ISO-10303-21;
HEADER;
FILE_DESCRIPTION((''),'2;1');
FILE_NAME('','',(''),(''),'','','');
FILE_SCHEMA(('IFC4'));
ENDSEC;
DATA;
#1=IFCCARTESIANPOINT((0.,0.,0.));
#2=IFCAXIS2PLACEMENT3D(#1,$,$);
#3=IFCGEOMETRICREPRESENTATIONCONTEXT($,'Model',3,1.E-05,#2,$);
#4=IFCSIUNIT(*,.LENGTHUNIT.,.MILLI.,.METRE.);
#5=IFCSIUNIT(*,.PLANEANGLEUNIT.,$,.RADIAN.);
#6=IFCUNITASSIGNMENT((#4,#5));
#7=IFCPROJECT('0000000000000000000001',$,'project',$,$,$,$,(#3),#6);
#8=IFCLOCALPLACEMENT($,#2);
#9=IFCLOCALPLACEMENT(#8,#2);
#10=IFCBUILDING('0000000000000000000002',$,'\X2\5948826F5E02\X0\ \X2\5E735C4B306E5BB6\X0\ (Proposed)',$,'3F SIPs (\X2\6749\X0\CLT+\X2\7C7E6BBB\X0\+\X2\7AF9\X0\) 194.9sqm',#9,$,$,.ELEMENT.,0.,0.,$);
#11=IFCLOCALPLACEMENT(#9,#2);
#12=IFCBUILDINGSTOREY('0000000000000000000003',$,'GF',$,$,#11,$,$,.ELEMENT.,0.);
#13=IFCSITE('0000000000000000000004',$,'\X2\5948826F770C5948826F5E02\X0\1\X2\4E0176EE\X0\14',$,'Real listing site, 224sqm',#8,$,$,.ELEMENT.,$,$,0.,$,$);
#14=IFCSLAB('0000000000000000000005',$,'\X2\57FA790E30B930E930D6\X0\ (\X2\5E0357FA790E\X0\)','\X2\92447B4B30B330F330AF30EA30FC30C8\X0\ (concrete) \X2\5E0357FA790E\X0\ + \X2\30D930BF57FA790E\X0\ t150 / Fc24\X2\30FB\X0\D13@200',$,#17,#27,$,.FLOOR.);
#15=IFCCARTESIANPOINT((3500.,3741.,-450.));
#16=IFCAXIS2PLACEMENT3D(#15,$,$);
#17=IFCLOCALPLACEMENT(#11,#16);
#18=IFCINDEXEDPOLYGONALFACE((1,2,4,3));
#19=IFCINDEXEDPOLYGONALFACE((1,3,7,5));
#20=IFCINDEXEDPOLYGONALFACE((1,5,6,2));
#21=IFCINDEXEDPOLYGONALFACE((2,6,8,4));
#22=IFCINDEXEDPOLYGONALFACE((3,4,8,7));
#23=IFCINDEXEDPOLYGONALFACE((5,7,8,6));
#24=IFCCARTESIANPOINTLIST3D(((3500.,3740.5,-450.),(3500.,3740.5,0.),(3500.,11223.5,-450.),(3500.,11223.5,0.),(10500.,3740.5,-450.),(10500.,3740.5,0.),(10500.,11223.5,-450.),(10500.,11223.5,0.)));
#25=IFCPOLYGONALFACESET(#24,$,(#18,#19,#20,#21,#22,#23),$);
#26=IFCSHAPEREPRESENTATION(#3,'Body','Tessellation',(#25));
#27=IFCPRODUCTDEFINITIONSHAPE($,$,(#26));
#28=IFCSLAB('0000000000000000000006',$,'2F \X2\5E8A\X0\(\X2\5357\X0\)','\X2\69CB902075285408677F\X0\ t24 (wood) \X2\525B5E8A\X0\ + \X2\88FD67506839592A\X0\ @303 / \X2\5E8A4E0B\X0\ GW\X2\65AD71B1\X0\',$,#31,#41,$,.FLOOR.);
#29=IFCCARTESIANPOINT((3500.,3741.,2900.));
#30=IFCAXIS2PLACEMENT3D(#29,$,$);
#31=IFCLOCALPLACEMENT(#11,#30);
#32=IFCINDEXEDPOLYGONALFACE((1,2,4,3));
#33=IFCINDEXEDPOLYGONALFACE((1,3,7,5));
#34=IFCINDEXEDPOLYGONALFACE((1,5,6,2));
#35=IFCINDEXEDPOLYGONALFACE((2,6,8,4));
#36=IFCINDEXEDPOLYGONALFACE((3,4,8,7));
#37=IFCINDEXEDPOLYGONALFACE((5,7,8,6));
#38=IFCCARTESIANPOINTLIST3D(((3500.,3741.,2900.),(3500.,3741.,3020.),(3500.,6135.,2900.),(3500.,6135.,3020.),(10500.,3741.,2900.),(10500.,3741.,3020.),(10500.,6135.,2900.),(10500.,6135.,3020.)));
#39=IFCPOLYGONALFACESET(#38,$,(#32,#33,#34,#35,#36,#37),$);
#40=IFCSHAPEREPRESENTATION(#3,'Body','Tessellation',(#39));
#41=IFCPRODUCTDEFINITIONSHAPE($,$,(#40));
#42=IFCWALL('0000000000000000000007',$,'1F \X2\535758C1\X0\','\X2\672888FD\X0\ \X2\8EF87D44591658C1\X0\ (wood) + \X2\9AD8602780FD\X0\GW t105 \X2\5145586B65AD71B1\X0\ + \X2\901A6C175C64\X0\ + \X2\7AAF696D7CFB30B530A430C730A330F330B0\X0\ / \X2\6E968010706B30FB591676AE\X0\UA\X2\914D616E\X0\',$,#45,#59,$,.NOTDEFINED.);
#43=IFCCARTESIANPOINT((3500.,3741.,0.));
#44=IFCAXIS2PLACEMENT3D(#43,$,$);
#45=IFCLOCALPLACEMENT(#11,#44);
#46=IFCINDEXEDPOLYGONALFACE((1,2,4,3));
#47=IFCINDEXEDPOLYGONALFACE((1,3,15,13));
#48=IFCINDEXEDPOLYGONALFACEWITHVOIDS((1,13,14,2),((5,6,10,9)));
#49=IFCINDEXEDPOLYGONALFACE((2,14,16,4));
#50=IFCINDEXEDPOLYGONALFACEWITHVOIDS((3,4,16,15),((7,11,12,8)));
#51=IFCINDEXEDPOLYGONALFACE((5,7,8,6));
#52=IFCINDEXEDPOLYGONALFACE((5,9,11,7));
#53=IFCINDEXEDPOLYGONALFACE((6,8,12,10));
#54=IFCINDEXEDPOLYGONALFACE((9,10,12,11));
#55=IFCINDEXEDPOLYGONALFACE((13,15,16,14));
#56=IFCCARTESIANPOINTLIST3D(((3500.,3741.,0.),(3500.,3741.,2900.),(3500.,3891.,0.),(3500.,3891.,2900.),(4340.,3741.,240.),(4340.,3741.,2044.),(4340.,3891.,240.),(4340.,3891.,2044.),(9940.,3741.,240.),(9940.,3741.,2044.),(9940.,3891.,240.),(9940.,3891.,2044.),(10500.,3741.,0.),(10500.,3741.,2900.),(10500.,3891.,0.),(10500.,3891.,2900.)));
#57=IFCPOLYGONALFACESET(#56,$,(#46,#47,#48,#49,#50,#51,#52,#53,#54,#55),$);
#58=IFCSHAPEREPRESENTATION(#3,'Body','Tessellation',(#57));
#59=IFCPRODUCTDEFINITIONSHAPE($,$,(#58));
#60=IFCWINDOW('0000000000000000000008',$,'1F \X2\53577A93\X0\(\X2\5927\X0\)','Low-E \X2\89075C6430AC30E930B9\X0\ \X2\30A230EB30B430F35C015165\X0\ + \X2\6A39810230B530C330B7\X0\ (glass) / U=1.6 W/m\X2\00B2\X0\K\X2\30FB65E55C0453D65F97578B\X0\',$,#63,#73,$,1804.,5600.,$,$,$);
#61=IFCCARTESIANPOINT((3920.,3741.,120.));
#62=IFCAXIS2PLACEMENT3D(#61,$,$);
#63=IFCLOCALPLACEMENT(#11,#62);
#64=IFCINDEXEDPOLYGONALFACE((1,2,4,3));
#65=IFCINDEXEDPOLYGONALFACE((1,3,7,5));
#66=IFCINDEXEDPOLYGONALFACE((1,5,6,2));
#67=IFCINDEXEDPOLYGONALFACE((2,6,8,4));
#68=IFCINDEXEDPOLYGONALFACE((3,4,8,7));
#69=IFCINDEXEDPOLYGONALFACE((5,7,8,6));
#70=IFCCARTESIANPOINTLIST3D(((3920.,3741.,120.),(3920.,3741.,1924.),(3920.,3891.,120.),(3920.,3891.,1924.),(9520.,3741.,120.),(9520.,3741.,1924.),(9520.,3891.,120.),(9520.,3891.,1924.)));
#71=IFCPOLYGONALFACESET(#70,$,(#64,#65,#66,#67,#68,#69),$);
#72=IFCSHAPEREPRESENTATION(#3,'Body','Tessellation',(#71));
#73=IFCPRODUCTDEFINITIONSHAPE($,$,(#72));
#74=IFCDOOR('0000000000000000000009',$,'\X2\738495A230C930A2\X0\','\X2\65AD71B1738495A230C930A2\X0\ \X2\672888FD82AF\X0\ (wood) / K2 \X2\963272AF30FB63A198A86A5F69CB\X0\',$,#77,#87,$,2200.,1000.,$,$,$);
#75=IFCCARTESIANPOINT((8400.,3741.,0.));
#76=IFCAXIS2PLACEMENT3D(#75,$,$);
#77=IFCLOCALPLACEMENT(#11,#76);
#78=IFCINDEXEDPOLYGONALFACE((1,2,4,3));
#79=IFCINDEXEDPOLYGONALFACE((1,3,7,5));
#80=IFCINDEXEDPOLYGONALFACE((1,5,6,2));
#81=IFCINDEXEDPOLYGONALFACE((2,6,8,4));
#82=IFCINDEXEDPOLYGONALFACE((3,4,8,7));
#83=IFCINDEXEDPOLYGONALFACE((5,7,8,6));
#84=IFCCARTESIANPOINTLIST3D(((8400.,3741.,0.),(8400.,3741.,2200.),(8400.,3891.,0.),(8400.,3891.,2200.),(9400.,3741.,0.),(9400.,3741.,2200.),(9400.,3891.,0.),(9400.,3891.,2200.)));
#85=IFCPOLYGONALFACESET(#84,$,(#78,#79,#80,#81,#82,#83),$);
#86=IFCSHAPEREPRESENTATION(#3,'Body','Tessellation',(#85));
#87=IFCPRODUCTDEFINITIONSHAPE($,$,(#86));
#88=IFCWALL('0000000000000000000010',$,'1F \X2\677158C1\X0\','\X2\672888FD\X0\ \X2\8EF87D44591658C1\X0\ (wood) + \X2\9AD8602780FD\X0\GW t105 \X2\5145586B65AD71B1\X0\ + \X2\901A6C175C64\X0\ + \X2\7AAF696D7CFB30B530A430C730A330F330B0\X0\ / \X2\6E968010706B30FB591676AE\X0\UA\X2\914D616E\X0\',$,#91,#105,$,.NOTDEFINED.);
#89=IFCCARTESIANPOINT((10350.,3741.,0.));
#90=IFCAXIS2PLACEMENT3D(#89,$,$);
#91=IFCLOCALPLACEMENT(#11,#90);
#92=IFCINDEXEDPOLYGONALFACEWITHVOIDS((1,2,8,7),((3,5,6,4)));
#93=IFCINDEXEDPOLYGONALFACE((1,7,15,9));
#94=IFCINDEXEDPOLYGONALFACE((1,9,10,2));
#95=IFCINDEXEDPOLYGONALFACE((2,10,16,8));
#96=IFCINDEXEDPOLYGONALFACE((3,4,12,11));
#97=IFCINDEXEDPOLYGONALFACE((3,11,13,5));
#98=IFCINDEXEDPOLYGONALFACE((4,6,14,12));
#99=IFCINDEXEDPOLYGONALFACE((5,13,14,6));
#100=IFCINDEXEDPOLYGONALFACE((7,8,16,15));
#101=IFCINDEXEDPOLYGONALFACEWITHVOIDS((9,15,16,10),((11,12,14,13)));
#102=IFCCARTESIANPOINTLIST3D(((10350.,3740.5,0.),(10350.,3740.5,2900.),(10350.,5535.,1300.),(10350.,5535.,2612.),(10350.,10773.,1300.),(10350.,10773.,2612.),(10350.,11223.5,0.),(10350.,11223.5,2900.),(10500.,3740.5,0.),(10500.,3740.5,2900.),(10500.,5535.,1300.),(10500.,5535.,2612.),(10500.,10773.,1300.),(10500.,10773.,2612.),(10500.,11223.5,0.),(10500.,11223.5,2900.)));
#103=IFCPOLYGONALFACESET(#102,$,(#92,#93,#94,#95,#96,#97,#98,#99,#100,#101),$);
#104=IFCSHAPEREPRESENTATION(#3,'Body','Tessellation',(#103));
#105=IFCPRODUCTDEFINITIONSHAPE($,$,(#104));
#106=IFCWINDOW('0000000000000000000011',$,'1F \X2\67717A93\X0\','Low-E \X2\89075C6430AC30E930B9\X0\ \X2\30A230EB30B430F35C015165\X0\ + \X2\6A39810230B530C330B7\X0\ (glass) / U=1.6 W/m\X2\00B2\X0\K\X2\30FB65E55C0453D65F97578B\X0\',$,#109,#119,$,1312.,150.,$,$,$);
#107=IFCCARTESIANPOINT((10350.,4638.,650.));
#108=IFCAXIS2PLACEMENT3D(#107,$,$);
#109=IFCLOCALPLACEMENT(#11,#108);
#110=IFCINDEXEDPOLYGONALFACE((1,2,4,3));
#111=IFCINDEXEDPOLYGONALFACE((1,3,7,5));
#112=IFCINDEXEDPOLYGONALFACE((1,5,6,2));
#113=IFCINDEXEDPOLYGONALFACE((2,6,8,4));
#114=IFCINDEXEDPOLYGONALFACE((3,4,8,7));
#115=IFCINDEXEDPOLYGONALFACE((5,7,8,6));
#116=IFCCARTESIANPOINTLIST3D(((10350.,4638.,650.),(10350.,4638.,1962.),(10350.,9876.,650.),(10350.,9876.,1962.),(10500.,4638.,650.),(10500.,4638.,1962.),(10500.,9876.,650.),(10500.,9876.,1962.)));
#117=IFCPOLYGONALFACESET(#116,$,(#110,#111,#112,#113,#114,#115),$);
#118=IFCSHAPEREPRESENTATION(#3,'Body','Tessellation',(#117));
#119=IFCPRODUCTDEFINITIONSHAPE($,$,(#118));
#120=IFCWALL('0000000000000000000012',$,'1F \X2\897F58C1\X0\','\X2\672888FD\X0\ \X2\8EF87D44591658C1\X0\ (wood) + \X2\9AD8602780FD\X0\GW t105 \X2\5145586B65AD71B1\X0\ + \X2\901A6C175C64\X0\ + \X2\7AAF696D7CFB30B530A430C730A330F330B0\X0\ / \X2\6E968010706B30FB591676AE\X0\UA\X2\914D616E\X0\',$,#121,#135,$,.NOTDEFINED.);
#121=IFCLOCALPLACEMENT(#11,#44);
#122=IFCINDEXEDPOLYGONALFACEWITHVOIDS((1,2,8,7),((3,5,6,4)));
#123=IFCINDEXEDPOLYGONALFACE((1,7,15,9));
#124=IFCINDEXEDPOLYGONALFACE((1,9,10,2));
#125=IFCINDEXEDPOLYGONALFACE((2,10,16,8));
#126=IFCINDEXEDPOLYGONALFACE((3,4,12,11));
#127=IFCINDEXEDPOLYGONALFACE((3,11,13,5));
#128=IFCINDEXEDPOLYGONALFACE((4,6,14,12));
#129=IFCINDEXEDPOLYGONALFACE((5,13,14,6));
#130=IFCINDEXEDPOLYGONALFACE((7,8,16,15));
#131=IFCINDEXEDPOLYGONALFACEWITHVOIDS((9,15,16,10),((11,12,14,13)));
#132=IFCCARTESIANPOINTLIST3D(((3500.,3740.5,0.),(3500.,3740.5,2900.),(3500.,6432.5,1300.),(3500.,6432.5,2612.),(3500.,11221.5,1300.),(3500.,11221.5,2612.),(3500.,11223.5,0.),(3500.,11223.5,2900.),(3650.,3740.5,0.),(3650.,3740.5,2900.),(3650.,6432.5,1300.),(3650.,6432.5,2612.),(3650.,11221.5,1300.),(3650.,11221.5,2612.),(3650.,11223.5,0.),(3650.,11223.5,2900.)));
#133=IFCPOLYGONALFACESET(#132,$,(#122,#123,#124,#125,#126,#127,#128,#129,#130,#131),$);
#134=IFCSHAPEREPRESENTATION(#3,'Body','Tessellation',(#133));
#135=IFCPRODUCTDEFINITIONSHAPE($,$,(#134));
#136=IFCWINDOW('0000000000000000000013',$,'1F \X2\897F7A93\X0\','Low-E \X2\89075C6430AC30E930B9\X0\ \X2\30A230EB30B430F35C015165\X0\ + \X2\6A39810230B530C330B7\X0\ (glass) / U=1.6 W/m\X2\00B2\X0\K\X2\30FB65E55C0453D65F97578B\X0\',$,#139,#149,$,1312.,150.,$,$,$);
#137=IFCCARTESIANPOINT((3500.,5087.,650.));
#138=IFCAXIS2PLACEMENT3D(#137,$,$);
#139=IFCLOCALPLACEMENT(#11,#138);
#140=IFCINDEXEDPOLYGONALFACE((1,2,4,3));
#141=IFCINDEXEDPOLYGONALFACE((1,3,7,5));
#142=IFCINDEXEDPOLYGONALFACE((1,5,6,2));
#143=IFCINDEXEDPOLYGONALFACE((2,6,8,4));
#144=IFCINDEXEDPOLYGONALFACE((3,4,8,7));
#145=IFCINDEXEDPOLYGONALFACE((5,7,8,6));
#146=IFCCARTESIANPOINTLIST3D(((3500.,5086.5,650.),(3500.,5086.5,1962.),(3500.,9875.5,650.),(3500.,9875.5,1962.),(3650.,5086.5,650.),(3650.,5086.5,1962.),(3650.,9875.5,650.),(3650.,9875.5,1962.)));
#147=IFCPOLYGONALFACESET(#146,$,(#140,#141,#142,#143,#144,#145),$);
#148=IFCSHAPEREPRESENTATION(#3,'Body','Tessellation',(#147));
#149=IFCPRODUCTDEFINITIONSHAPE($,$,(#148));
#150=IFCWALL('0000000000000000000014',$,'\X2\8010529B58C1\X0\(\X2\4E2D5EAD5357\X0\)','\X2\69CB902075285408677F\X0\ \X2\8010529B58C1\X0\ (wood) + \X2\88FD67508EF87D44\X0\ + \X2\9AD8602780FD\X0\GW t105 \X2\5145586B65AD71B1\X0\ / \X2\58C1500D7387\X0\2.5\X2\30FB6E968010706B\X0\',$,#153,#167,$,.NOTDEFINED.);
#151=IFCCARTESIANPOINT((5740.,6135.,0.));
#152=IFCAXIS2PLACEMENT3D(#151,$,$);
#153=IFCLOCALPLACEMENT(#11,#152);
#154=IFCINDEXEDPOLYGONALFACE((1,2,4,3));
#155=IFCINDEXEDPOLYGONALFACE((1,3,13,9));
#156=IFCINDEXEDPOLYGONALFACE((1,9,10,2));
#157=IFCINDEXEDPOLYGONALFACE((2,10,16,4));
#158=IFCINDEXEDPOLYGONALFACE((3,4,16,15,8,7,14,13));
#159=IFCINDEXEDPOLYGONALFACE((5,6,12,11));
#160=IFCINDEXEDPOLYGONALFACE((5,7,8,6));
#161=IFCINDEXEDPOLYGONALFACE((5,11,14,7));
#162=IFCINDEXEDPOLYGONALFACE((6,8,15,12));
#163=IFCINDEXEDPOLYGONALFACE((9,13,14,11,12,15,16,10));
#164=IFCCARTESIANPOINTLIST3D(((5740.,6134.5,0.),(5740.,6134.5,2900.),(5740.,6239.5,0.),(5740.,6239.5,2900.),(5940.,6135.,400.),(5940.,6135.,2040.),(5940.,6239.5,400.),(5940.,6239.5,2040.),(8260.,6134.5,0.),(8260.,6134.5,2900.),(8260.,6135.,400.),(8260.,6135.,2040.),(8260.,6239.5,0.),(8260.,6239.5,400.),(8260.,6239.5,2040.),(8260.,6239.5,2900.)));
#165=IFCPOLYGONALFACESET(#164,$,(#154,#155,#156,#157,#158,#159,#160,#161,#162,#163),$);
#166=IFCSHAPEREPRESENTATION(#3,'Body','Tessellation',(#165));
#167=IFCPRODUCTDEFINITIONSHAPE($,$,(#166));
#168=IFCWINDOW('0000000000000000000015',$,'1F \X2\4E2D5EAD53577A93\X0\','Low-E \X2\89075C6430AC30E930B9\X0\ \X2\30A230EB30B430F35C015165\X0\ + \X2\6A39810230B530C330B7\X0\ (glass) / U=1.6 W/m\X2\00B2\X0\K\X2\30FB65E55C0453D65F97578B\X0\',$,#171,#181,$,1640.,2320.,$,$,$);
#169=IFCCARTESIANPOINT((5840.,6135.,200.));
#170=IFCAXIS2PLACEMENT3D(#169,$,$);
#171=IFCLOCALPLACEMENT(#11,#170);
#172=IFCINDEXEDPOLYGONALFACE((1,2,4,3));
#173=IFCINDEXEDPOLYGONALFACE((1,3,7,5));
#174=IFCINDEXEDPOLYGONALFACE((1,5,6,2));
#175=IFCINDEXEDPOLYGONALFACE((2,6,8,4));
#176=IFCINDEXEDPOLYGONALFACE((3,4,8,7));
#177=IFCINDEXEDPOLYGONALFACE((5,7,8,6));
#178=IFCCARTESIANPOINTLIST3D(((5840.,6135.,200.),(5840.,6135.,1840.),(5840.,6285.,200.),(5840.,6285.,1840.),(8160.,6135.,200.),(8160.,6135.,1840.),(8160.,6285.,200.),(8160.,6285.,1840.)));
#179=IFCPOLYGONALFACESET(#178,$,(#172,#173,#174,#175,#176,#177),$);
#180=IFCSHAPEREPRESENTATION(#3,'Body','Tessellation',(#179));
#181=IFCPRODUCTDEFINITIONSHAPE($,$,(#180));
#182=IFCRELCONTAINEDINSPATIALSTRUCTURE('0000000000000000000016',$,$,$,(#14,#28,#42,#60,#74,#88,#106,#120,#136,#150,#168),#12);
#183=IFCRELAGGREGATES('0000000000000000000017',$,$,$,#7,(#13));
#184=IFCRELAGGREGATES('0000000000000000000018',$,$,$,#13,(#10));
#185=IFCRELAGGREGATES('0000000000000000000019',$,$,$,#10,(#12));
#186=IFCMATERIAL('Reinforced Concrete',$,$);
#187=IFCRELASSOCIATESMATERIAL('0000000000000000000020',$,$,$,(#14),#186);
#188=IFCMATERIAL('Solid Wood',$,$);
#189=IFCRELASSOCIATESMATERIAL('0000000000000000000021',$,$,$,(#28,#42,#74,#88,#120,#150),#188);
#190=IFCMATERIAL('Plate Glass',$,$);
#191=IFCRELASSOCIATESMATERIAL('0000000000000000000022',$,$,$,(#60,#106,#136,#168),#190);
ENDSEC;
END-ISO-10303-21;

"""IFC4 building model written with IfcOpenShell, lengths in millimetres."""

from ifc_helpers import new_model, si_unit, frame, frame_2d, origin, place, context, project, spatial, rectangle, extrude, material, element, fill, save


model = new_model("IFC4")

# Units and contexts
model_context = context("Model", 3, precision=1e-05, world=origin())
ifc_project = project(units=[si_unit("LENGTHUNIT", "METRE", prefix="MILLI"), si_unit("PLANEANGLEUNIT", "RADIAN")], contexts=[model_context])

# Site, building, storey
site_placement = place(None, origin())
site = spatial("IfcSite", under=ifc_project, at=site_placement, Name="奈良県奈良市1丁目14", ObjectType="Real listing site, 224sqm", CompositionType="ELEMENT", RefElevation=0.0)
building_placement = place(site_placement, origin())
building = spatial("IfcBuilding", under=site, at=building_placement, Name="奈良市 平屋の家 (Proposed)", ObjectType="3F SIPs (杉CLT+籾殻+竹) 194.9sqm", CompositionType="ELEMENT", ElevationOfRefHeight=0.0, ElevationOfTerrain=0.0)
storey_placement = place(building_placement, origin())
storey = spatial("IfcBuildingStorey", under=building, at=storey_placement, Name="GF", CompositionType="ELEMENT", Elevation=0.0)

# Slabs
ifc_material_1 = material(Name="Reinforced Concrete")
slab_1_placement = place(storey_placement, frame((3500.0, 3741.0, -450.0)))
element("IfcSlab", 1, at=slab_1_placement, inside=storey, material=ifc_material_1, Name="基礎スラブ (布基礎)", Description="鉄筋コンクリート (concrete) 布基礎 + ベタ基礎 t150 / Fc24・D13@200", PredefinedType="FLOOR", context=model_context, shape_type="SweptSolid", body=[
    extrude(rectangle(XDim=7000.0, YDim=7483.0, at=frame_2d((3500.0, 3741.0))), frame((3500.0, 3741.0, -450.0)), (0.0, 0.0, 1.0), 450.0),
])
ifc_material_2 = material(Name="Solid Wood")
slab_2_placement = place(storey_placement, frame((3500.0, 3741.0, 2900.0)))
element("IfcSlab", 2, at=slab_2_placement, inside=storey, material=ifc_material_2, Name="2F 床(南)", Description="構造用合板 t24 (wood) 剛床 + 製材根太 @303 / 床下 GW断熱", PredefinedType="FLOOR", context=model_context, shape_type="SweptSolid", body=[
    extrude(rectangle(XDim=7000.0, YDim=2394.0, at=frame_2d((3500.0, 1197.0))), frame((3500.0, 3741.0, 2900.0)), (0.0, 0.0, 1.0), 120.0),
])

# Wall, openings, window, door
wall_1_placement = place(storey_placement, frame((3500.0, 3741.0, 0.0)))
wall_1 = element("IfcWall", 3, at=wall_1_placement, inside=storey, material=ifc_material_2, Name="1F 南壁", Description="木製 軸組外壁 (wood) + 高性能GW t105 充填断熱 + 通気層 + 窯業系サイディング / 準耐火・外皮UA配慮", PredefinedType="NOTDEFINED", context=model_context, shape_type="SweptSolid", body=[
    extrude(rectangle(XDim=7000.0, YDim=150.0, at=frame_2d((3500.0, 75.0))), frame((3500.0, 3741.0, 0.0)), (0.0, 0.0, 1.0), 2900.0),
])
opening_1_placement = place(storey_placement, frame((3920.0, 3741.0, 120.0)))
opening_1 = element("IfcOpeningElement", 4, at=opening_1_placement, cuts=wall_1, PredefinedType="NOTDEFINED", context=model_context, shape_type="SweptSolid", body=[
    extrude(rectangle(XDim=5600.0, YDim=150.0, at=frame_2d((2800.0, 75.0))), frame((3920.0, 3741.0, 120.0)), (0.0, 0.0, 1.0), 1804.0),
])
opening_2_placement = place(storey_placement, frame((8400.0, 3741.0, 0.0)))
opening_2 = element("IfcOpeningElement", 5, at=opening_2_placement, cuts=wall_1, PredefinedType="NOTDEFINED", context=model_context, shape_type="SweptSolid", body=[
    extrude(rectangle(XDim=1000.0, YDim=150.0, at=frame_2d((500.0, 75.0))), frame((8400.0, 3741.0, 0.0)), (0.0, 0.0, 1.0), 2200.0),
])
ifc_material_3 = material(Name="Plate Glass")
window_1_placement = place(storey_placement, frame((3920.0, 3741.0, 120.0)))
window_1 = element("IfcWindow", 6, at=window_1_placement, inside=storey, material=ifc_material_3, Name="1F 南窓(大)", Description="Low-E 複層ガラス アルゴン封入 + 樹脂サッシ (glass) / U=1.6 W/m²K・日射取得型", OverallHeight=1804.0, OverallWidth=5600.0, context=model_context, shape_type="SweptSolid", body=[
    extrude(rectangle(XDim=5600.0, YDim=150.0, at=frame_2d((2800.0, 75.0))), frame((3920.0, 3741.0, 120.0)), (0.0, 0.0, 1.0), 1804.0),
])
fill(opening_1, window_1)
door_placement = place(storey_placement, frame((8400.0, 3741.0, 0.0)))
door = element("IfcDoor", 7, at=door_placement, inside=storey, material=ifc_material_2, Name="玄関ドア", Description="断熱玄関ドア 木製芯 (wood) / K2 防犯・採風機構", OverallHeight=2200.0, OverallWidth=1000.0, context=model_context, shape_type="SweptSolid", body=[
    extrude(rectangle(XDim=1000.0, YDim=150.0, at=frame_2d((500.0, 75.0))), frame((8400.0, 3741.0, 0.0)), (0.0, 0.0, 1.0), 2200.0),
])
fill(opening_2, door)

# Walls, openings, windows
wall_2_placement = place(storey_placement, frame((10350.0, 3741.0, 0.0)))
wall_2 = element("IfcWall", 8, at=wall_2_placement, inside=storey, material=ifc_material_2, Name="1F 東壁", Description="木製 軸組外壁 (wood) + 高性能GW t105 充填断熱 + 通気層 + 窯業系サイディング / 準耐火・外皮UA配慮", PredefinedType="NOTDEFINED", context=model_context, shape_type="SweptSolid", body=[
    extrude(rectangle(XDim=150.0, YDim=7483.0, at=frame_2d((75.0, 3741.0))), frame((10350.0, 3741.0, 0.0)), (0.0, 0.0, 1.0), 2900.0),
])
opening_3_placement = place(storey_placement, frame((10350.0, 4638.0, 650.0)))
opening_3 = element("IfcOpeningElement", 9, at=opening_3_placement, cuts=wall_2, PredefinedType="NOTDEFINED", context=model_context, shape_type="SweptSolid", body=[
    extrude(rectangle(XDim=150.0, YDim=5238.0, at=frame_2d((75.0, 2619.0))), frame((10350.0, 4638.0, 650.0)), (0.0, 0.0, 1.0), 1312.0),
])
window_2_placement = place(storey_placement, frame((10350.0, 4638.0, 650.0)))
window_2 = element("IfcWindow", 10, at=window_2_placement, inside=storey, material=ifc_material_3, Name="1F 東窓", Description="Low-E 複層ガラス アルゴン封入 + 樹脂サッシ (glass) / U=1.6 W/m²K・日射取得型", OverallHeight=1312.0, OverallWidth=150.0, context=model_context, shape_type="SweptSolid", body=[
    extrude(rectangle(XDim=150.0, YDim=5238.0, at=frame_2d((75.0, 2619.0))), frame((10350.0, 4638.0, 650.0)), (0.0, 0.0, 1.0), 1312.0),
])
fill(opening_3, window_2)
wall_3_placement = place(storey_placement, frame((3500.0, 3741.0, 0.0)))
wall_3 = element("IfcWall", 11, at=wall_3_placement, inside=storey, material=ifc_material_2, Name="1F 西壁", Description="木製 軸組外壁 (wood) + 高性能GW t105 充填断熱 + 通気層 + 窯業系サイディング / 準耐火・外皮UA配慮", PredefinedType="NOTDEFINED", context=model_context, shape_type="SweptSolid", body=[
    extrude(rectangle(XDim=150.0, YDim=7483.0, at=frame_2d((75.0, 3741.0))), frame((3500.0, 3741.0, 0.0)), (0.0, 0.0, 1.0), 2900.0),
])
opening_4_placement = place(storey_placement, frame((3500.0, 5087.0, 650.0)))
opening_4 = element("IfcOpeningElement", 12, at=opening_4_placement, cuts=wall_3, PredefinedType="NOTDEFINED", context=model_context, shape_type="SweptSolid", body=[
    extrude(rectangle(XDim=150.0, YDim=4789.0, at=frame_2d((75.0, 2394.0))), frame((3500.0, 5087.0, 650.0)), (0.0, 0.0, 1.0), 1312.0),
])
window_3_placement = place(storey_placement, frame((3500.0, 5087.0, 650.0)))
window_3 = element("IfcWindow", 13, at=window_3_placement, inside=storey, material=ifc_material_3, Name="1F 西窓", Description="Low-E 複層ガラス アルゴン封入 + 樹脂サッシ (glass) / U=1.6 W/m²K・日射取得型", OverallHeight=1312.0, OverallWidth=150.0, context=model_context, shape_type="SweptSolid", body=[
    extrude(rectangle(XDim=150.0, YDim=4789.0, at=frame_2d((75.0, 2394.0))), frame((3500.0, 5087.0, 650.0)), (0.0, 0.0, 1.0), 1312.0),
])
fill(opening_4, window_3)
wall_4_placement = place(storey_placement, frame((5740.0, 6135.0, 0.0)))
wall_4 = element("IfcWall", 14, at=wall_4_placement, inside=storey, material=ifc_material_2, Name="耐力壁(中庭南)", Description="構造用合板 耐力壁 (wood) + 製材軸組 + 高性能GW t105 充填断熱 / 壁倍率2.5・準耐火", PredefinedType="NOTDEFINED", context=model_context, shape_type="SweptSolid", body=[
    extrude(rectangle(XDim=2520.0, YDim=105.0, at=frame_2d((1260.0, 52.0))), frame((5740.0, 6135.0, 0.0)), (0.0, 0.0, 1.0), 2900.0),
])
opening_5_placement = place(storey_placement, frame((5840.0, 6135.0, 200.0)))
opening_5 = element("IfcOpeningElement", 15, at=opening_5_placement, cuts=wall_4, PredefinedType="NOTDEFINED", context=model_context, shape_type="SweptSolid", body=[
    extrude(rectangle(XDim=2320.0, YDim=150.0, at=frame_2d((1160.0, 75.0))), frame((5840.0, 6135.0, 200.0)), (0.0, 0.0, 1.0), 1640.0),
])
window_4_placement = place(storey_placement, frame((5840.0, 6135.0, 200.0)))
window_4 = element("IfcWindow", 16, at=window_4_placement, inside=storey, material=ifc_material_3, Name="1F 中庭南窓", Description="Low-E 複層ガラス アルゴン封入 + 樹脂サッシ (glass) / U=1.6 W/m²K・日射取得型", OverallHeight=1640.0, OverallWidth=2320.0, context=model_context, shape_type="SweptSolid", body=[
    extrude(rectangle(XDim=2320.0, YDim=150.0, at=frame_2d((1160.0, 75.0))), frame((5840.0, 6135.0, 200.0)), (0.0, 0.0, 1.0), 1640.0),
])
fill(opening_5, window_4)

save(model, "model.ifc")
